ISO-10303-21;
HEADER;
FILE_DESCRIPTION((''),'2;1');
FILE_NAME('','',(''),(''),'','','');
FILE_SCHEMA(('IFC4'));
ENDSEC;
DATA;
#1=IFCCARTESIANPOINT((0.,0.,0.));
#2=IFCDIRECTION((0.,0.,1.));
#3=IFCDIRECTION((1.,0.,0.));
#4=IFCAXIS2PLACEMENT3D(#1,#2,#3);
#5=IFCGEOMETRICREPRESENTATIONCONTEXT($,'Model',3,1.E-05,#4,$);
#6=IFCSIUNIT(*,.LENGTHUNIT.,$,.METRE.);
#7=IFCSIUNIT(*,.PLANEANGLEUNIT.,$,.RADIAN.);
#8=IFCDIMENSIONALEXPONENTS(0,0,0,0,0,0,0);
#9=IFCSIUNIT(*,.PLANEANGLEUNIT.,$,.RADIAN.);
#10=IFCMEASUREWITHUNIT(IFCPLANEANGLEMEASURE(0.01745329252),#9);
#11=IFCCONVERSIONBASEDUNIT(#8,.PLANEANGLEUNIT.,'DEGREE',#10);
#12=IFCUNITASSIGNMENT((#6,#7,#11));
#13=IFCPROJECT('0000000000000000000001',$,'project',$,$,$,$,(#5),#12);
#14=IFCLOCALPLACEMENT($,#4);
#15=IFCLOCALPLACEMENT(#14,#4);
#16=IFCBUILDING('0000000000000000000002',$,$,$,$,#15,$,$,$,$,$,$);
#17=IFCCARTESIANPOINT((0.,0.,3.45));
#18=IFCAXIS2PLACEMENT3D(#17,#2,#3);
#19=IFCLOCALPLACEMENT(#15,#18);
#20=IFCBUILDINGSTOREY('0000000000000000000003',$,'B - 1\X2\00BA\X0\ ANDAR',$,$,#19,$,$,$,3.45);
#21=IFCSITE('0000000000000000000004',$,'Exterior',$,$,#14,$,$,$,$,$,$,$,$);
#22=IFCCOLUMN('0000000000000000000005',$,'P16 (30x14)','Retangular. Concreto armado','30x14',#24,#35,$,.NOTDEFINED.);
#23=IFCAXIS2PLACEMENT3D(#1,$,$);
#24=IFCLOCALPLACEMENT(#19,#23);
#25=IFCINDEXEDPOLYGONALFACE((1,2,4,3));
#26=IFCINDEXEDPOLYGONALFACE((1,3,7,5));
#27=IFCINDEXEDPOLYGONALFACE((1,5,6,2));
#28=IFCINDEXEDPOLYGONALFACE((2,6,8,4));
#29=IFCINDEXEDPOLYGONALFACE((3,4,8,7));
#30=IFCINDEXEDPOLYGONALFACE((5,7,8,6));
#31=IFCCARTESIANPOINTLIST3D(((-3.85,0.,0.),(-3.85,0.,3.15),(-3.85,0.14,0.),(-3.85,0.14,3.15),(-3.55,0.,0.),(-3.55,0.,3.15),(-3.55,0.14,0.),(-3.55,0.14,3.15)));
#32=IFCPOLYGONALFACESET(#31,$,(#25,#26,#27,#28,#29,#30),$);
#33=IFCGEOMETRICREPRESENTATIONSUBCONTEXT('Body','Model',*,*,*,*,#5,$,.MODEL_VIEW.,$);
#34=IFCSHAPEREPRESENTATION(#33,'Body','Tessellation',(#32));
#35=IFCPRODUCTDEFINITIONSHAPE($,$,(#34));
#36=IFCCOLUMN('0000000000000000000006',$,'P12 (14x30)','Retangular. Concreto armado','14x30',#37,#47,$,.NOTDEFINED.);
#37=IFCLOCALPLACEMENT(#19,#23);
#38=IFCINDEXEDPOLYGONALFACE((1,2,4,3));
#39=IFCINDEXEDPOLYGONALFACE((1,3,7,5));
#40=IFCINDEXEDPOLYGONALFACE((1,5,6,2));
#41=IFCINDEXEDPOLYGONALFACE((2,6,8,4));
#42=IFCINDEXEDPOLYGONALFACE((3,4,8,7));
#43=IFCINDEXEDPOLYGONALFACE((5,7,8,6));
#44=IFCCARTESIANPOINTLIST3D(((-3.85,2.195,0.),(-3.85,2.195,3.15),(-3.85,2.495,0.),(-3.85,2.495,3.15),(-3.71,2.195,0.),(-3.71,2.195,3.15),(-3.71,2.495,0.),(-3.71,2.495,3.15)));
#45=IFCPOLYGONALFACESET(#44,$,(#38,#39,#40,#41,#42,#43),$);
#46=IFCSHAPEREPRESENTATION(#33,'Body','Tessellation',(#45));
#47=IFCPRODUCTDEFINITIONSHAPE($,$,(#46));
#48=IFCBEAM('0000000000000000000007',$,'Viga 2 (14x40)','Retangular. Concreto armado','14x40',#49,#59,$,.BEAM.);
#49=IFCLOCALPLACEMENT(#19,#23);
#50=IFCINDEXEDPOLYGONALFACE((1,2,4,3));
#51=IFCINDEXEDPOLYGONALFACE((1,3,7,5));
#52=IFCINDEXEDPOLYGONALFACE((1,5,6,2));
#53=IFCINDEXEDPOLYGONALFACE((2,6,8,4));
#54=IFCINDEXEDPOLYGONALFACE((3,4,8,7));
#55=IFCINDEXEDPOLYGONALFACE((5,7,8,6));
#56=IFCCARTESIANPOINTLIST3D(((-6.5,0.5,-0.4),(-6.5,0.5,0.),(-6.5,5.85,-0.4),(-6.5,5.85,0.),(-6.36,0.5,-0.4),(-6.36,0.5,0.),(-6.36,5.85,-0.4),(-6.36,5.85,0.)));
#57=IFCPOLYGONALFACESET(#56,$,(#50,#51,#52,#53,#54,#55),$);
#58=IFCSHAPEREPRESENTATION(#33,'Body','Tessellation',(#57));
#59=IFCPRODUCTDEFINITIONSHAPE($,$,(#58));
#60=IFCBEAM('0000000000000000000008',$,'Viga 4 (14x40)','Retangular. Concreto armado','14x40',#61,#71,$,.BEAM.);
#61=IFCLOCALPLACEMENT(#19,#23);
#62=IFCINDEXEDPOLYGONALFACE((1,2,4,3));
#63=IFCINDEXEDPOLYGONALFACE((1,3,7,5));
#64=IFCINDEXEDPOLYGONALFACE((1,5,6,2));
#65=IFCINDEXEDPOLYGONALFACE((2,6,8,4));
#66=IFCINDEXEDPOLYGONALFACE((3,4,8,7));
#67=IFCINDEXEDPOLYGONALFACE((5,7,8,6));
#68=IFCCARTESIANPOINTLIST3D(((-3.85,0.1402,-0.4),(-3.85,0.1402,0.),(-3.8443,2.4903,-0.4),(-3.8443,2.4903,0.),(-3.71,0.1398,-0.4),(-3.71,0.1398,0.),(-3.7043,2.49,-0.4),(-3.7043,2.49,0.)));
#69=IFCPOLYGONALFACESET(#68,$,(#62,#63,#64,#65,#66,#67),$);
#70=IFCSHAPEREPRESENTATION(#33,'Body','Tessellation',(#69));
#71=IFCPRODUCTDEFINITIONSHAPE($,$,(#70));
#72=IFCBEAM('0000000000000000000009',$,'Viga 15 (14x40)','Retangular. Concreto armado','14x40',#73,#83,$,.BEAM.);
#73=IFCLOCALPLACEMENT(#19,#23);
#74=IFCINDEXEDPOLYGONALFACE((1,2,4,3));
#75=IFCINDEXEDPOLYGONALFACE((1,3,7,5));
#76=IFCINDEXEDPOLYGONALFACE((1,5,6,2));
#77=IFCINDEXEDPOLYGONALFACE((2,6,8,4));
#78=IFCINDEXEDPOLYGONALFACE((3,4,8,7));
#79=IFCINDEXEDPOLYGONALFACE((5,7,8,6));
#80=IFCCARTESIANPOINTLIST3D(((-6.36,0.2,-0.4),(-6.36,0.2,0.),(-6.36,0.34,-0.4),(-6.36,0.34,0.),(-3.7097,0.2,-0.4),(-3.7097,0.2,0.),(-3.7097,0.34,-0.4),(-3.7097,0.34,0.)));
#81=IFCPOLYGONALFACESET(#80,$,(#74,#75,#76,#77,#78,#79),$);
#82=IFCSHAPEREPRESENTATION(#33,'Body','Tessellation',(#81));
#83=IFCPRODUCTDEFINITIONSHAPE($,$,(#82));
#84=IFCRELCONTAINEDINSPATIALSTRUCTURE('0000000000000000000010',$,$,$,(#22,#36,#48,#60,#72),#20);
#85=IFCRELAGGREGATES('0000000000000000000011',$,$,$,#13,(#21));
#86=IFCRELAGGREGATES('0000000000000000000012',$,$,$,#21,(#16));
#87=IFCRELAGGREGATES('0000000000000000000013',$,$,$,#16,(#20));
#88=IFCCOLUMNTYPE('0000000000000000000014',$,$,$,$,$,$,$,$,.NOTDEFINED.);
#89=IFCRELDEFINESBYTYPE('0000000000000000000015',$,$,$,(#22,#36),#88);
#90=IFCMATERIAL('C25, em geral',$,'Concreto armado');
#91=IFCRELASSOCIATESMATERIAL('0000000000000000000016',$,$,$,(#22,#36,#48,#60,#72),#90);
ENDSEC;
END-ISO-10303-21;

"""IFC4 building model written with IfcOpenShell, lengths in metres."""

from ifc_helpers import new_model, entity, si_unit, converted_unit, frame, frame_2d, origin_with_axes, origin_2d_with_axis, place, context, subcontext, project, spatial, rectangle, extrude, material, type_object, element, save


model = new_model("IFC4")

# Units and contexts
model_context = context("Model", 3, precision=1e-05, world=origin_with_axes())
body_context = subcontext(model_context, "Body", "Model", "MODEL_VIEW")
ifc_project = project(units=[si_unit("LENGTHUNIT", "METRE"), si_unit("PLANEANGLEUNIT", "RADIAN"), converted_unit("PLANEANGLEUNIT", "DEGREE", entity("IfcPlaneAngleMeasure", 0.01745329252), si_unit("PLANEANGLEUNIT", "RADIAN"), dimensions=[0, 0, 0, 0, 0, 0, 0])], contexts=[model_context])

# Site, building, storey
site_placement = place(None, origin_with_axes())
site = spatial("IfcSite", under=ifc_project, at=site_placement, Name="Exterior")
building_placement = place(site_placement, origin_with_axes())
building = spatial("IfcBuilding", under=site, at=building_placement)
storey_placement = place(building_placement, frame((0.0, 0.0, 3.45), z_axis=(0.0, 0.0, 1.0), x_axis=(1.0, 0.0, 0.0)))
storey = spatial("IfcBuildingStorey", under=building, at=storey_placement, Name="B - 1º ANDAR", Elevation=3.45)

# Columns
ifc_material = material(Name="C25, em geral", Category="Concreto armado")
column_type = type_object("IfcColumnType", PredefinedType="NOTDEFINED")
column_1_placement = place(storey_placement, frame((-3.7, 0.07, 0.0), z_axis=(0.0, 0.0, 1.0), x_axis=(1.0, 0.0, 0.0)))
element("IfcColumn", 1, at=column_1_placement, inside=storey, type_object=column_type, material=ifc_material, Name="P16 (30x14)", Description="Retangular. Concreto armado", ObjectType="30x14", PredefinedType="NOTDEFINED", context=body_context, shape_type="SweptSolid", body=[
    extrude(rectangle(XDim=0.3, YDim=0.14, at=origin_2d_with_axis()), origin_with_axes(), (0.0, 0.0, 1.0), 3.15),
])
column_2_placement = place(storey_placement, frame((-3.78, 2.345, 0.0), z_axis=(0.0, 0.0, 1.0), x_axis=(1.0, 0.0, 0.0)))
element("IfcColumn", 2, at=column_2_placement, inside=storey, type_object=column_type, material=ifc_material, Name="P12 (14x30)", Description="Retangular. Concreto armado", ObjectType="14x30", PredefinedType="NOTDEFINED", context=body_context, shape_type="SweptSolid", body=[
    extrude(rectangle(XDim=0.14, YDim=0.3, at=origin_2d_with_axis()), origin_with_axes(), (0.0, 0.0, 1.0), 3.15),
])

# Beams
beam_1_placement = place(storey_placement, frame((-6.43, 0.5, 0.0), z_axis=(0.0, 1.0, 0.0), x_axis=(-1.0, 0.0, 0.0)))
element("IfcBeam", 3, at=beam_1_placement, inside=storey, material=ifc_material, Name="Viga 2 (14x40)", Description="Retangular. Concreto armado", ObjectType="14x40", PredefinedType="BEAM", context=body_context, shape_type="SweptSolid", body=[
    extrude(rectangle(XDim=0.14, YDim=0.4, at=frame_2d((0.0, -0.2), x_axis=(1.0, 0.0))), origin_with_axes(), (0.0, 0.0, 1.0), 5.35),
])
beam_2_placement = place(storey_placement, frame((-3.78, 0.14, 0.0), z_axis=(0.002427, 0.999997, 0.0), x_axis=(-0.999997, 0.002427, 0.0)))
element("IfcBeam", 4, at=beam_2_placement, inside=storey, material=ifc_material, Name="Viga 4 (14x40)", Description="Retangular. Concreto armado", ObjectType="14x40", PredefinedType="BEAM", context=body_context, shape_type="SweptSolid", body=[
    extrude(rectangle(XDim=0.14, YDim=0.4, at=frame_2d((0.0, -0.2), x_axis=(1.0, 0.0))), origin_with_axes(), (0.0, 0.0, 1.0), 2.3502),
])
beam_3_placement = place(storey_placement, frame((-6.36, 0.27, 0.0), z_axis=(1.0, 0.0, 0.0), x_axis=(0.0, 1.0, 0.0)))
element("IfcBeam", 5, at=beam_3_placement, inside=storey, material=ifc_material, Name="Viga 15 (14x40)", Description="Retangular. Concreto armado", ObjectType="14x40", PredefinedType="BEAM", context=body_context, shape_type="SweptSolid", body=[
    extrude(rectangle(XDim=0.14, YDim=0.4, at=frame_2d((0.0, -0.2), x_axis=(1.0, 0.0))), origin_with_axes(), (0.0, 0.0, 1.0), 2.6503),
])

save(model, "model.ifc")
